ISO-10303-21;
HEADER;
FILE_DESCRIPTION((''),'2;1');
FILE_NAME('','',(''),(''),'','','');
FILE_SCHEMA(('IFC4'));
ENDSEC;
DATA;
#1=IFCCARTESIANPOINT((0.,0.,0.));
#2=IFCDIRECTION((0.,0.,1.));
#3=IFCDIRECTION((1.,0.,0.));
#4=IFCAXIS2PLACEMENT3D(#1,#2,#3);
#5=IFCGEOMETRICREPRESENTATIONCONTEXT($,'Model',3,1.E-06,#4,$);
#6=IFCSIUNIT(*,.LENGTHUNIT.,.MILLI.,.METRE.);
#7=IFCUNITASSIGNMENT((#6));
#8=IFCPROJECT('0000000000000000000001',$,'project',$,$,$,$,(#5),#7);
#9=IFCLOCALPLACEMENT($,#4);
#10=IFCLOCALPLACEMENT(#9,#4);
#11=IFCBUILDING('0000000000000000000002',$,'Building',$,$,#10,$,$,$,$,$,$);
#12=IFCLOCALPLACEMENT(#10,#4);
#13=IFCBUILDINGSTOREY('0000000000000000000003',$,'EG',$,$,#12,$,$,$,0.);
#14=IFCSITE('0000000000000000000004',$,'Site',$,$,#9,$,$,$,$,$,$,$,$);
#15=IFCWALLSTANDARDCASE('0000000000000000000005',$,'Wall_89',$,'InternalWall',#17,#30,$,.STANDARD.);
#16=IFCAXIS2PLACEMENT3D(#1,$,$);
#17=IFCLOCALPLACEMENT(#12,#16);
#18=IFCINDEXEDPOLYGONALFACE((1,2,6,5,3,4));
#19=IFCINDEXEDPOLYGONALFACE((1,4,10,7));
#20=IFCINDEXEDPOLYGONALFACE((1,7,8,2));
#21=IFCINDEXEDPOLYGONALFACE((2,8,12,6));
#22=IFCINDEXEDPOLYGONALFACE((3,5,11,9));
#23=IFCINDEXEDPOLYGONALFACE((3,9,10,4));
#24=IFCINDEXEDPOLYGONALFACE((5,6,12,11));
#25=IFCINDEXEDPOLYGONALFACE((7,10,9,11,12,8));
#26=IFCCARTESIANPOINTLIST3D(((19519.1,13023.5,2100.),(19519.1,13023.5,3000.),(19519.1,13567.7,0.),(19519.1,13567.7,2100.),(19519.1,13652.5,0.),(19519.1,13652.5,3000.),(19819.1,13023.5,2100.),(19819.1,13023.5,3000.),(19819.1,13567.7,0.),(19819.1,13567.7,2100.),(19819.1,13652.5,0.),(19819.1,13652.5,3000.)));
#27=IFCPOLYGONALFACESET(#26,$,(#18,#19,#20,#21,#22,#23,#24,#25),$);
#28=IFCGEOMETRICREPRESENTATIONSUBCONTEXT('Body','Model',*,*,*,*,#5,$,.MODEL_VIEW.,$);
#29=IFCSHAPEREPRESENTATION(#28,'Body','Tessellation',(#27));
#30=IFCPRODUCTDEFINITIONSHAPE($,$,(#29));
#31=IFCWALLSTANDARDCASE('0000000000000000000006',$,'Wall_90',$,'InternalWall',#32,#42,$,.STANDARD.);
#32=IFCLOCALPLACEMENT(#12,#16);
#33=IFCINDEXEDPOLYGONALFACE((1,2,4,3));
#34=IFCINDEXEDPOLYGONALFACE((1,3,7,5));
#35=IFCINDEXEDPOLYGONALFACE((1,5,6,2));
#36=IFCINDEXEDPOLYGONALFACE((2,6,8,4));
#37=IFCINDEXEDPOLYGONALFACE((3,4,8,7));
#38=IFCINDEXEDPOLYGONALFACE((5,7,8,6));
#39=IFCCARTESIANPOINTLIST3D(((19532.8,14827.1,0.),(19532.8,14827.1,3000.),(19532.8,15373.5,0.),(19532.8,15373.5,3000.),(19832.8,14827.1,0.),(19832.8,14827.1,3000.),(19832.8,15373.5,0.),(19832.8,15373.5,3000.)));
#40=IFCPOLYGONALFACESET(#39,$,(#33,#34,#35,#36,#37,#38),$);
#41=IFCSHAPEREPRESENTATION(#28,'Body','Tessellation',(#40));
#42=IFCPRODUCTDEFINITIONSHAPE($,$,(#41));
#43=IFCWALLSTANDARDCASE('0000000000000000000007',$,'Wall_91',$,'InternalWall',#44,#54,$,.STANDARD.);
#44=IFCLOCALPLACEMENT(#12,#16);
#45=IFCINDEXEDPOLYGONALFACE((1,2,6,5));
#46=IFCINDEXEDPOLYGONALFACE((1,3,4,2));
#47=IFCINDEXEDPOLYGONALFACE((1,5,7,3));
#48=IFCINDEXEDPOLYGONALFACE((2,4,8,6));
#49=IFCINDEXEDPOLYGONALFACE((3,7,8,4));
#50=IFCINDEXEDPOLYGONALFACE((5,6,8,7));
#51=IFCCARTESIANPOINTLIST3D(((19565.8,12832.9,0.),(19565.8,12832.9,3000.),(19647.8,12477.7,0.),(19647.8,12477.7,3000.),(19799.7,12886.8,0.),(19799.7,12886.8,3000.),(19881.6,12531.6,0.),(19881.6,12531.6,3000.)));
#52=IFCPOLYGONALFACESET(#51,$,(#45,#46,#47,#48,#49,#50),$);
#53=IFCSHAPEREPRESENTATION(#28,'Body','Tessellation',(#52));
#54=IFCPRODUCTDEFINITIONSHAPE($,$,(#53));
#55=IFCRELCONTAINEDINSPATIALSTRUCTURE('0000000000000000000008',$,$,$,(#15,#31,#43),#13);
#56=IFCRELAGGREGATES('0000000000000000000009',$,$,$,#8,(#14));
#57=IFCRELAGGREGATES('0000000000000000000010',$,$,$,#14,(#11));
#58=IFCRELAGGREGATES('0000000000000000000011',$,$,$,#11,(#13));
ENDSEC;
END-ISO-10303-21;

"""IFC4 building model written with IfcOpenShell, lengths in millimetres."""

from ifc_helpers import new_model, si_unit, frame, origin_with_axes, place, context, subcontext, project, spatial, rectangle, extrude, element, save


model = new_model("IFC4")

# Units and contexts
model_context = context("Model", 3, precision=1e-06, world=origin_with_axes())
body_context = subcontext(model_context, "Body", "Model", "MODEL_VIEW")
ifc_project = project(units=[si_unit("LENGTHUNIT", "METRE", prefix="MILLI")], contexts=[model_context])

# Site, building, storey
site_placement = place(None, origin_with_axes())
site = spatial("IfcSite", under=ifc_project, at=site_placement, Name="Site")
building_placement = place(site_placement, origin_with_axes())
building = spatial("IfcBuilding", under=site, at=building_placement, Name="Building")
storey_placement = place(building_placement, origin_with_axes())
storey = spatial("IfcBuildingStorey", under=building, at=storey_placement, Name="EG", Elevation=0.0)

# Wall, opening
wall_1_placement = place(storey_placement, origin_with_axes())
wall_1 = element("IfcWallStandardCase", 1, at=wall_1_placement, inside=storey, Name="Wall_89", ObjectType="InternalWall", PredefinedType="STANDARD", context=body_context, shape_type="SweptSolid", body=[
    extrude(rectangle(XDim=629.0, YDim=300.0), frame((19669.1, 13338.0, 0.0), z_axis=(0.0, 0.0, 1.0), x_axis=(0.0, -1.0, 0.0)), (0.0, 0.0, 1.0), 3000.0),
])
opening_1_placement = place(wall_1_placement, origin_with_axes())
element("IfcOpeningElement", 2, at=opening_1_placement, inside=storey, cuts=wall_1, context=body_context, shape_type="SweptSolid", body=[
    extrude(rectangle(XDim=911.5, YDim=300.0), frame((19669.1, 13112.0, 0.0), z_axis=(0.0, 0.0, 1.0), x_axis=(0.0, -1.0, 0.0)), (0.0, 0.0, 1.0), 2100.0),
])

# Walls
wall_2_placement = place(storey_placement, origin_with_axes())
element("IfcWallStandardCase", 3, at=wall_2_placement, inside=storey, Name="Wall_90", ObjectType="InternalWall", PredefinedType="STANDARD", context=body_context, shape_type="SweptSolid", body=[
    extrude(rectangle(XDim=546.4, YDim=300.0), frame((19682.8, 15100.3, 0.0), z_axis=(0.0, 0.0, 1.0), x_axis=(0.0, 1.0, 0.0)), (0.0, 0.0, 1.0), 3000.0),
])
wall_3_placement = place(storey_placement, origin_with_axes())
element("IfcWallStandardCase", 4, at=wall_3_placement, inside=storey, Name="Wall_91", ObjectType="InternalWall", PredefinedType="STANDARD", context=body_context, shape_type="SweptSolid", body=[
    extrude(rectangle(XDim=364.5, YDim=240.0), frame((19723.7, 12682.2, 0.0), z_axis=(0.0, 0.0, 1.0), x_axis=(0.22486, -0.974391, 0.0)), (0.0, 0.0, 1.0), 3000.0),
])

save(model, "model.ifc")
